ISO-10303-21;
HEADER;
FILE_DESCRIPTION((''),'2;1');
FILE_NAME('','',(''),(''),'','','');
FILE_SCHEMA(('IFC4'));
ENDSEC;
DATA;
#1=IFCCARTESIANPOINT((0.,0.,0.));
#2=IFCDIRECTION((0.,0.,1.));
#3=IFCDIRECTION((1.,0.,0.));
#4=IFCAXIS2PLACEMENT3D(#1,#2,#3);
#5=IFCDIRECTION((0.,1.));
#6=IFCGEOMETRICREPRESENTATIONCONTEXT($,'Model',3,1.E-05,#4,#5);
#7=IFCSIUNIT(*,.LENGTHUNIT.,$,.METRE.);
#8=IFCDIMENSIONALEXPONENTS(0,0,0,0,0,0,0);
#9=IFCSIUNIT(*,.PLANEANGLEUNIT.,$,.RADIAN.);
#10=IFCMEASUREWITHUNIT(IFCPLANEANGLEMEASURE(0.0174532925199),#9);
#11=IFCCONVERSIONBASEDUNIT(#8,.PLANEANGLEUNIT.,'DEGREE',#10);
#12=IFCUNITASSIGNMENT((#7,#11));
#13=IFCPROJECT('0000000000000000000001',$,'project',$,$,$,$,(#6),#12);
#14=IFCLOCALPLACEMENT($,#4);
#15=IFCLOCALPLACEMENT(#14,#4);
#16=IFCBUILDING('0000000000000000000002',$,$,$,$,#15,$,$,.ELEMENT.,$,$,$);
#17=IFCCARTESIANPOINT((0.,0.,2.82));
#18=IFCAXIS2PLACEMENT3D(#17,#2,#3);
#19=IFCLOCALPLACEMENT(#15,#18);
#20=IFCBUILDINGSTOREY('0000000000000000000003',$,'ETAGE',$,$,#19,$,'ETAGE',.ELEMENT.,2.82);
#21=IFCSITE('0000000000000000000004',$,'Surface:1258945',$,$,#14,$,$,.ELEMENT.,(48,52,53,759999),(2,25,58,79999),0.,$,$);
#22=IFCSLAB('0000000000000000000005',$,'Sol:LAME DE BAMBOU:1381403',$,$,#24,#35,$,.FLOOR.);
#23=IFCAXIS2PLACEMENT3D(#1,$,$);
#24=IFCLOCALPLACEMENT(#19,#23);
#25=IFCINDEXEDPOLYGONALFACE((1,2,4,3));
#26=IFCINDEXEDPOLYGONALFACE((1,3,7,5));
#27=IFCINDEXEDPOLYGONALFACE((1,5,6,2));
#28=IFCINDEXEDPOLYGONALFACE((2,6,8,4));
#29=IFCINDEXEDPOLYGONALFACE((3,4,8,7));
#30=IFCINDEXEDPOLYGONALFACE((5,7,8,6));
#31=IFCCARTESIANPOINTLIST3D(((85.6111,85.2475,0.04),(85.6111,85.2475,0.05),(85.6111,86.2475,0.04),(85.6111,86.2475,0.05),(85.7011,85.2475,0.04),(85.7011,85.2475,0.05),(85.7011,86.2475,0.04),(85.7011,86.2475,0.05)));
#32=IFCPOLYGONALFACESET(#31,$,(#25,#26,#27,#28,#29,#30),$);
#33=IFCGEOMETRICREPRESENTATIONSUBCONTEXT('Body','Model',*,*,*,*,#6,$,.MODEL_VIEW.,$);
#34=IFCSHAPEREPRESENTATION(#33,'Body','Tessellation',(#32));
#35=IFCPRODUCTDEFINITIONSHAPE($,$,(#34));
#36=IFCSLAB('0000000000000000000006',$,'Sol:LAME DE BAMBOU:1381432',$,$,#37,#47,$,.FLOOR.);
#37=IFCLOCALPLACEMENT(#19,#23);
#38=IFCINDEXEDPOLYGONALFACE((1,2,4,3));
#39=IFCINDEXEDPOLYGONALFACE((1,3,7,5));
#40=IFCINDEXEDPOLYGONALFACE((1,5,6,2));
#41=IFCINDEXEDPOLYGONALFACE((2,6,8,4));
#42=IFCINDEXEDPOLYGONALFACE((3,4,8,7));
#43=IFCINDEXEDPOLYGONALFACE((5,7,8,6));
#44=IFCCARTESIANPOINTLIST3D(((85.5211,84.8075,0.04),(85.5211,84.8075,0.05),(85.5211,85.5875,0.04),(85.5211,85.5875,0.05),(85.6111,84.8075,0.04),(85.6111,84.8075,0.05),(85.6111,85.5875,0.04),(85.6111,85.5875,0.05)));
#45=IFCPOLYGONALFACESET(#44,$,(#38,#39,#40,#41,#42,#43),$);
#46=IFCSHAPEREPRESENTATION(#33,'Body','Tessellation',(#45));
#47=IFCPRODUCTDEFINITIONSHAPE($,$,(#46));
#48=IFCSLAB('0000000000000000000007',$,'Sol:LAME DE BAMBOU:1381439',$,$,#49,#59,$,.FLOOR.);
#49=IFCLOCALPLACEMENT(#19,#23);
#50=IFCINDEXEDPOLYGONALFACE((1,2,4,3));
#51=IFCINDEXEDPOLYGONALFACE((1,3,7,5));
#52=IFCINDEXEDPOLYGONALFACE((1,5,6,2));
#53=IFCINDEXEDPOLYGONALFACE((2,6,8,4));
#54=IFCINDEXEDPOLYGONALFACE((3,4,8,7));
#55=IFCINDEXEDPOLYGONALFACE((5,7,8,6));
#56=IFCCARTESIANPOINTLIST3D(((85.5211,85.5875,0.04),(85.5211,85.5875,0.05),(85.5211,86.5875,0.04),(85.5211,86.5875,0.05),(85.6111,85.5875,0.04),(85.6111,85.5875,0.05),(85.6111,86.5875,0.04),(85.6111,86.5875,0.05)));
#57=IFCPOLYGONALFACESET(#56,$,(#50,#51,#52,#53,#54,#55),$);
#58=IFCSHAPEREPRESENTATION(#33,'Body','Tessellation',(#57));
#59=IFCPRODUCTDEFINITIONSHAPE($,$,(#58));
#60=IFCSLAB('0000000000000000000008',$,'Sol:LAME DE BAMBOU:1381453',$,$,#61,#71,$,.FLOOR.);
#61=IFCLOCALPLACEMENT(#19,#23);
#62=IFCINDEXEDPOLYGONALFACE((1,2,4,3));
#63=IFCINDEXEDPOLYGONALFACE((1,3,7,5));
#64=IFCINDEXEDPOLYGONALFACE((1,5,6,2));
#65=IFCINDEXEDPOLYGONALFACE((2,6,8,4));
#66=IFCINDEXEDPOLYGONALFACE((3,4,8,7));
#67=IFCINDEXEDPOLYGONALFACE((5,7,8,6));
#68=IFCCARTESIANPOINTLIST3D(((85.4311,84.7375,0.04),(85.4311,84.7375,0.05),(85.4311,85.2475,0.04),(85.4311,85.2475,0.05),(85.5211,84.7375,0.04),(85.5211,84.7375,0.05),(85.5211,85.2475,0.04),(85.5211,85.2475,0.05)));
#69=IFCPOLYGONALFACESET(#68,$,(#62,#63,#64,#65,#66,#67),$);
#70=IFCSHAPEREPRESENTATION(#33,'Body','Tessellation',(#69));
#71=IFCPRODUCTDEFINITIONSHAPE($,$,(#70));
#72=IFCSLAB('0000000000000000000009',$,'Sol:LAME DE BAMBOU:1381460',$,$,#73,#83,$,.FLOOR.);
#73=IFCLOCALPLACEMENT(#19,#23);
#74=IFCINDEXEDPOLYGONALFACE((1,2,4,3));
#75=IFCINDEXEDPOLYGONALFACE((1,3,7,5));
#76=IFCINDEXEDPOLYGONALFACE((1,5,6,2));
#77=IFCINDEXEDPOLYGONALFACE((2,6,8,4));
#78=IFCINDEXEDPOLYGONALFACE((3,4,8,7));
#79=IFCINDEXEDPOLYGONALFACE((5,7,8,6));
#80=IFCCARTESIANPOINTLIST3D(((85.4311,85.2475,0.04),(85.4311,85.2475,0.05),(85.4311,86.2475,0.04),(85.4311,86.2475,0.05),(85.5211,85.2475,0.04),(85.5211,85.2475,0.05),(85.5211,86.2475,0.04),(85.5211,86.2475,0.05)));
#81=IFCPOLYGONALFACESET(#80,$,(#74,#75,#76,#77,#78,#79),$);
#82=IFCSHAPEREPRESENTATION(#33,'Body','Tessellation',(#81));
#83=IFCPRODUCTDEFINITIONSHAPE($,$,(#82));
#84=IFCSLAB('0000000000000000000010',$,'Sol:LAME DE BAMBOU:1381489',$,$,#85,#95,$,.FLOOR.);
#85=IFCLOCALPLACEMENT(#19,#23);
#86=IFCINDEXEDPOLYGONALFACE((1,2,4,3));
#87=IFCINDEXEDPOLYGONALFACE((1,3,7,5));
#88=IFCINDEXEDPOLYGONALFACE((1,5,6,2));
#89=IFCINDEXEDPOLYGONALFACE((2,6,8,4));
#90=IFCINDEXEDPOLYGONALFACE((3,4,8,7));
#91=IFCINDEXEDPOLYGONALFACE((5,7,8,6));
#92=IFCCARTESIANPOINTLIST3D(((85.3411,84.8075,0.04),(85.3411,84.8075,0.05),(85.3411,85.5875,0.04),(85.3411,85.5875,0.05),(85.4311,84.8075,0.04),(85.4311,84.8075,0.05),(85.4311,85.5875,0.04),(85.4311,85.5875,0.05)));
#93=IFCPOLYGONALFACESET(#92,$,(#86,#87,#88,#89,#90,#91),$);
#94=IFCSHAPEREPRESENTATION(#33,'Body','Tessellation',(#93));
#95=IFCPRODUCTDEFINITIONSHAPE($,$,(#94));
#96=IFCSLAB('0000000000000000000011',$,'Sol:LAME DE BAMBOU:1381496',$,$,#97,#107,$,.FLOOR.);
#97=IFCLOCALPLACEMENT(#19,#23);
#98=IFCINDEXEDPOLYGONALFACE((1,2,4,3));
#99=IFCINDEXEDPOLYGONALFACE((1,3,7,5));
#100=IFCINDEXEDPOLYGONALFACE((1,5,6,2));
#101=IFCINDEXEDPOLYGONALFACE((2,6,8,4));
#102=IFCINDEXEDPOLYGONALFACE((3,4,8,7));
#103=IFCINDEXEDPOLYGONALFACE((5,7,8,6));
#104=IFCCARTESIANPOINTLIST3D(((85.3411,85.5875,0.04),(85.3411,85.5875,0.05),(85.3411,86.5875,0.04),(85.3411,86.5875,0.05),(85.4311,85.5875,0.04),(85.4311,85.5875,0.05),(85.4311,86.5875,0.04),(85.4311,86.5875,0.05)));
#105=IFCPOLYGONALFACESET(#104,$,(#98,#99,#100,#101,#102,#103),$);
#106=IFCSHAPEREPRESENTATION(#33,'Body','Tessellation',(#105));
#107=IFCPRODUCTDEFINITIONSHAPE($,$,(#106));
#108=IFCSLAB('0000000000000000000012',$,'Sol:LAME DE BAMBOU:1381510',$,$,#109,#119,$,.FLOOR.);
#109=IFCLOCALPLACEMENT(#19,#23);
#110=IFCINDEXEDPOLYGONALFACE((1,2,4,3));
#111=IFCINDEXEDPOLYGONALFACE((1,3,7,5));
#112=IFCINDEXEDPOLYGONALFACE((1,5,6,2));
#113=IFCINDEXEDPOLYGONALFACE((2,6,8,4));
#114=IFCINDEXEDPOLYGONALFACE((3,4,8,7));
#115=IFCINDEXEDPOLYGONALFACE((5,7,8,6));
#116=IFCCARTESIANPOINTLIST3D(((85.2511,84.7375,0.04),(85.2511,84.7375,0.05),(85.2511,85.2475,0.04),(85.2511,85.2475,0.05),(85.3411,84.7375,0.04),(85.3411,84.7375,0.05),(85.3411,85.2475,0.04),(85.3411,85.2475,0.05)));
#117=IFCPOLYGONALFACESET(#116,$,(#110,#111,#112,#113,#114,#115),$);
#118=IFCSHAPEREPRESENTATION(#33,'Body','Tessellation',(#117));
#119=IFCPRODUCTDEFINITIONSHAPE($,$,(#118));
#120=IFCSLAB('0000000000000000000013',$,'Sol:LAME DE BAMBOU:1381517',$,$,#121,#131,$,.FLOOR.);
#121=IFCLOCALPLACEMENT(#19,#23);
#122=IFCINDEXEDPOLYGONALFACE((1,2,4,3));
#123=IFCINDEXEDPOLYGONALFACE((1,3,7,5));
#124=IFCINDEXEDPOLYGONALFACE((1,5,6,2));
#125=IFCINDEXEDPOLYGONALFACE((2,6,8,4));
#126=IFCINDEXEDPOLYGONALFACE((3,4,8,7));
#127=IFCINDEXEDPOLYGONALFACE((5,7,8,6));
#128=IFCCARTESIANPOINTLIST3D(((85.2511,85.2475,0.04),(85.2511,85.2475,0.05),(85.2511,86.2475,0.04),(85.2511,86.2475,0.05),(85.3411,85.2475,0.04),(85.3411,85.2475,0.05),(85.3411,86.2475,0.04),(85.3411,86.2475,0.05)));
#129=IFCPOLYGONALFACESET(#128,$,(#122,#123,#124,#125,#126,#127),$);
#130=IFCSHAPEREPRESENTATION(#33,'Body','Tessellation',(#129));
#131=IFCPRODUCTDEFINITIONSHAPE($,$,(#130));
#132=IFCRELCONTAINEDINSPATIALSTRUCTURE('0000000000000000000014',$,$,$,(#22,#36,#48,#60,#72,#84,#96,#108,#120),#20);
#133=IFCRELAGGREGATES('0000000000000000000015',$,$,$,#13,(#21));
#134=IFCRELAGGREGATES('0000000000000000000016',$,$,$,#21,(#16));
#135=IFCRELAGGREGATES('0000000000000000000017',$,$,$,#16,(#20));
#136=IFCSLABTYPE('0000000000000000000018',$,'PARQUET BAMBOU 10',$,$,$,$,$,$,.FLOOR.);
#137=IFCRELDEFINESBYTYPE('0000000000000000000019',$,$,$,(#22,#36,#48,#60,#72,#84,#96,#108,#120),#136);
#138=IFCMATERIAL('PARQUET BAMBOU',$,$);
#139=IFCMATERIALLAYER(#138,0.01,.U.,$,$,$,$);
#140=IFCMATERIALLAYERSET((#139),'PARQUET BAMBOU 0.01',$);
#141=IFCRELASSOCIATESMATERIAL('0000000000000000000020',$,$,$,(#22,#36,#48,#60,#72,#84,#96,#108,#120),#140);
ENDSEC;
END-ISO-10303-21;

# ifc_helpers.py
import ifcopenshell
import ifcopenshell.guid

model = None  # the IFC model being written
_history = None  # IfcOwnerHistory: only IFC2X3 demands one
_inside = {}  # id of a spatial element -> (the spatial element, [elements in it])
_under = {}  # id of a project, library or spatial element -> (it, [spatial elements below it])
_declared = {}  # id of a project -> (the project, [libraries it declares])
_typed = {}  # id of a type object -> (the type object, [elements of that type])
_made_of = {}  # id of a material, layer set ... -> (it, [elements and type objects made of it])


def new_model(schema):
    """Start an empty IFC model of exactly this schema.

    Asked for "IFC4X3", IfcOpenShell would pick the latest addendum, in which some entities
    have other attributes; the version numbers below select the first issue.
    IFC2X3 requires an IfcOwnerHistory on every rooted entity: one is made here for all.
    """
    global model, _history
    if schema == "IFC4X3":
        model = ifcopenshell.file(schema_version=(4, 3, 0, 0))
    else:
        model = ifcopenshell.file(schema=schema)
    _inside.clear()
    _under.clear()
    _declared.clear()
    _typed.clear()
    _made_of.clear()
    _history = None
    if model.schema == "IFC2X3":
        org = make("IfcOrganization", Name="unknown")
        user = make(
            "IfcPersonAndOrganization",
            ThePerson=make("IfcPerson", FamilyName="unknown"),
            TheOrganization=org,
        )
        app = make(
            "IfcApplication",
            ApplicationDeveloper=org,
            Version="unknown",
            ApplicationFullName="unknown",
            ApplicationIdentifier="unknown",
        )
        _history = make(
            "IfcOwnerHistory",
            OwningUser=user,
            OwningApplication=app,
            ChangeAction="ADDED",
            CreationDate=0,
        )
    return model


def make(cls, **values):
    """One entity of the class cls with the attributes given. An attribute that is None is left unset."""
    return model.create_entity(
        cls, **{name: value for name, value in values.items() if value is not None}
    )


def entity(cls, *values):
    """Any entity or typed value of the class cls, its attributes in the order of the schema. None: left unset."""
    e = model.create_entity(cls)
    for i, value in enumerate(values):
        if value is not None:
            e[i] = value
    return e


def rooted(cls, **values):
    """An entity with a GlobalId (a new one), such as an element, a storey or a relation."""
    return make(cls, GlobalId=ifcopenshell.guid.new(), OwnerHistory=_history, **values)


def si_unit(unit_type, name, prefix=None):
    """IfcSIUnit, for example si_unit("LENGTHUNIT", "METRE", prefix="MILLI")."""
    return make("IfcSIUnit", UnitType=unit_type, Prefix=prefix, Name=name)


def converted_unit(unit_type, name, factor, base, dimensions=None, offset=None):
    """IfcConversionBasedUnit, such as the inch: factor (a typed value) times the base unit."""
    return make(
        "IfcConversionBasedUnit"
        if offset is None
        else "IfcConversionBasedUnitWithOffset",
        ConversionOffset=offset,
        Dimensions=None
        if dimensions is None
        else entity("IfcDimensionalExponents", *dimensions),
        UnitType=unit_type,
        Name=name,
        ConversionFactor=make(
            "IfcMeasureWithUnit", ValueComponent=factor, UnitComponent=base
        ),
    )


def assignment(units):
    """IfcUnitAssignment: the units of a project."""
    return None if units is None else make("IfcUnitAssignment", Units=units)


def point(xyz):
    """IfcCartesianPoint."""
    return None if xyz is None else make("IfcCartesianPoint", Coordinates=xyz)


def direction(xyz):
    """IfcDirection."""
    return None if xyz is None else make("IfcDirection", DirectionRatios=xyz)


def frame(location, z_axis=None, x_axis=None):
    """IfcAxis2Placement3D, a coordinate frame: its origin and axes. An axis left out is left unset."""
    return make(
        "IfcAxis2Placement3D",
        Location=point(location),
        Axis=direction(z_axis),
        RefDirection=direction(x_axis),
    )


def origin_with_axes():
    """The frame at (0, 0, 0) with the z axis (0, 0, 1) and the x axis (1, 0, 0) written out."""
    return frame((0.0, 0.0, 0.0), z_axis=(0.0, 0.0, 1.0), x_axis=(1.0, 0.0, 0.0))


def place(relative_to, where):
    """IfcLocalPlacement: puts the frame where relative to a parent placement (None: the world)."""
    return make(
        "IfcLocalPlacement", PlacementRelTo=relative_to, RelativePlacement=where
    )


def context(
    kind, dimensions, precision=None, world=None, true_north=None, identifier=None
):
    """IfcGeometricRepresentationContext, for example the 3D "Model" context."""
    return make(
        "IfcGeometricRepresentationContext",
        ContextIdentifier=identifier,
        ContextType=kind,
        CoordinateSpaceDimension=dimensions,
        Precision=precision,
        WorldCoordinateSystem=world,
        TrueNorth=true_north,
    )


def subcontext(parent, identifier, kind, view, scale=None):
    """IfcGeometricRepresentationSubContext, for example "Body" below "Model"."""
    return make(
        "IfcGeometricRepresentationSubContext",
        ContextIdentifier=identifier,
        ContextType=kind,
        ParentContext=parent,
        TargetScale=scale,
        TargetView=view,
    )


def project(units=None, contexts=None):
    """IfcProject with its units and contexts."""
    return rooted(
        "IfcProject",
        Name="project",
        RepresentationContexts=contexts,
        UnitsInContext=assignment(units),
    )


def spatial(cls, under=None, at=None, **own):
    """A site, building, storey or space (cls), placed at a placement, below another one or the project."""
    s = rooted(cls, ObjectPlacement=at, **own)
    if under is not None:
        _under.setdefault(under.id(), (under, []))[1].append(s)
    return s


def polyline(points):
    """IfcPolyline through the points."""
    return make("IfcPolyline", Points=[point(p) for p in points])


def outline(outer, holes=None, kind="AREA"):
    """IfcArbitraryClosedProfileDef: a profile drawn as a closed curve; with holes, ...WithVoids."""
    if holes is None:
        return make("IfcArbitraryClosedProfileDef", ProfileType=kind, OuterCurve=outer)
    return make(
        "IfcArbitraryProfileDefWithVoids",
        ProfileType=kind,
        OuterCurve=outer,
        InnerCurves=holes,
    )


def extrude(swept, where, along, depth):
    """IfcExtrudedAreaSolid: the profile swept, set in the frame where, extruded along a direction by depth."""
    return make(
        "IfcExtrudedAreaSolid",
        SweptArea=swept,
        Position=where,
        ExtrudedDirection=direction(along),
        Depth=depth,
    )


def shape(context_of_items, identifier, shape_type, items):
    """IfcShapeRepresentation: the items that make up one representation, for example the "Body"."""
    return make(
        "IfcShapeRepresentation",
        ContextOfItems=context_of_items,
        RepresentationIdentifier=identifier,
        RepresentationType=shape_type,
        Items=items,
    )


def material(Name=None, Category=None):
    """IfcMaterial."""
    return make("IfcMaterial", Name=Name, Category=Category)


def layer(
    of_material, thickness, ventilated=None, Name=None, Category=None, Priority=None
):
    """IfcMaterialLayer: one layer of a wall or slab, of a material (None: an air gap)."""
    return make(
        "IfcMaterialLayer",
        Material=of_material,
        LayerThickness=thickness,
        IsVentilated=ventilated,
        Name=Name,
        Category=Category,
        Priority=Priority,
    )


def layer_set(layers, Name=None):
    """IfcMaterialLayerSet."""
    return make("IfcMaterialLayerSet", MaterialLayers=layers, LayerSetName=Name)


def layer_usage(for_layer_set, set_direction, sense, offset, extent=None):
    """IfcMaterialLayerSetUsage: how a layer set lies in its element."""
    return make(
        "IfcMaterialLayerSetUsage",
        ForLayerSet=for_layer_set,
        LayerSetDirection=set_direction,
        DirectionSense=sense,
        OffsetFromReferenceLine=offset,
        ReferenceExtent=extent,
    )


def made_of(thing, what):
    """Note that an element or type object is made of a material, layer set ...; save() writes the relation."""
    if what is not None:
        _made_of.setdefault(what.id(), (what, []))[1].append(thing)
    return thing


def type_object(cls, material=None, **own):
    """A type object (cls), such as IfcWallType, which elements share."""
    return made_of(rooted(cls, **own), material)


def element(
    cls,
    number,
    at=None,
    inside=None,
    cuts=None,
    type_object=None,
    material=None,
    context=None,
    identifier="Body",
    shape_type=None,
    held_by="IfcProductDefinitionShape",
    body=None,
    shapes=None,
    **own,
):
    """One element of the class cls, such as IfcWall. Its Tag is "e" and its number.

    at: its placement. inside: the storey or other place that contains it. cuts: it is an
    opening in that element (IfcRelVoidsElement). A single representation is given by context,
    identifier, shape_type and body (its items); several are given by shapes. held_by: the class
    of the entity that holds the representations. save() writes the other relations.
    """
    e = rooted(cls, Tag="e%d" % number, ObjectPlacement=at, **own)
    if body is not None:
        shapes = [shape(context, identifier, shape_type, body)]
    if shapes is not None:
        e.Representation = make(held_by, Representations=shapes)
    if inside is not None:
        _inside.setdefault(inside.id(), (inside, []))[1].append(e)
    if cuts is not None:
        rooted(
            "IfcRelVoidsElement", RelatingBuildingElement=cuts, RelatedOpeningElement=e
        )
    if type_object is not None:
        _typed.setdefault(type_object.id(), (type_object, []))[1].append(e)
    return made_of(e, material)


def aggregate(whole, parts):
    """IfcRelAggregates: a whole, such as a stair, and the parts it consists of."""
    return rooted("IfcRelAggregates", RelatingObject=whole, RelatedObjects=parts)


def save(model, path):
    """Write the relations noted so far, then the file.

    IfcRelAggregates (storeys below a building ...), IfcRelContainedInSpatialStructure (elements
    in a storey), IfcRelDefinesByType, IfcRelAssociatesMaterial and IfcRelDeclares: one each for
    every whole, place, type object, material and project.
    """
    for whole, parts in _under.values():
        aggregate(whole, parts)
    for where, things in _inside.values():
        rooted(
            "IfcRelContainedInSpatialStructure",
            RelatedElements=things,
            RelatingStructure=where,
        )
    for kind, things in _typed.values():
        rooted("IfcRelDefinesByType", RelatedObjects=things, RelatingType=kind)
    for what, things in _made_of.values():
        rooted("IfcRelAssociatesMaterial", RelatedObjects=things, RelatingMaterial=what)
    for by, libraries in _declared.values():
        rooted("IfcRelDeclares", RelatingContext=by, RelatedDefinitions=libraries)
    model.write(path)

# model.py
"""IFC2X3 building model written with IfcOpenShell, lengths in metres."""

from ifc_helpers import new_model, entity, si_unit, converted_unit, direction, frame, origin_with_axes, place, context, subcontext, project, spatial, polyline, outline, extrude, material, layer, layer_set, layer_usage, type_object, element, save


model = new_model("IFC2X3")

# Units and contexts
model_context = context("Model", 3, precision=1e-05, world=origin_with_axes(), true_north=direction((0.0, 1.0)))
body_context = subcontext(model_context, "Body", "Model", "MODEL_VIEW")
ifc_project = project(units=[si_unit("LENGTHUNIT", "METRE"), converted_unit("PLANEANGLEUNIT", "DEGREE", entity("IfcPlaneAngleMeasure", 0.0174532925199), si_unit("PLANEANGLEUNIT", "RADIAN"), dimensions=[0, 0, 0, 0, 0, 0, 0])], contexts=[model_context])

# Site, building, storey
site_placement = place(None, origin_with_axes())
site = spatial("IfcSite", under=ifc_project, at=site_placement, Name="Surface:1258945", CompositionType="ELEMENT", RefLatitude=(48, 52, 53, 759999), RefLongitude=(2, 25, 58, 79999), RefElevation=0.0)
building_placement = place(site_placement, origin_with_axes())
building = spatial("IfcBuilding", under=site, at=building_placement, CompositionType="ELEMENT")
storey_placement = place(building_placement, frame((0.0, 0.0, 2.82), z_axis=(0.0, 0.0, 1.0), x_axis=(1.0, 0.0, 0.0)))
storey = spatial("IfcBuildingStorey", under=building, at=storey_placement, Name="ETAGE", LongName="ETAGE", CompositionType="ELEMENT", Elevation=2.82)

# Slabs
ifc_material = material(Name="PARQUET BAMBOU")
ifc_layer = layer(ifc_material, 0.01, ventilated="UNKNOWN")
ifc_layer_set = layer_set([ifc_layer], Name="PARQUET BAMBOU 0.01")
slab_type = type_object("IfcSlabType", Name="PARQUET BAMBOU 10", PredefinedType="FLOOR")
ifc_layer_usage_1 = layer_usage(ifc_layer_set, "AXIS3", "NEGATIVE", 0.01)
slab_1_placement = place(storey_placement, frame((85.6111, 86.2475, 0.05), z_axis=(0.0, 0.0, 1.0), x_axis=(1.0, 0.0, 0.0)))
element("IfcSlab", 1, at=slab_1_placement, inside=storey, type_object=slab_type, material=ifc_layer_usage_1, Name="Sol:LAME DE BAMBOU:1381403", PredefinedType="FLOOR", context=body_context, shape_type="SweptSolid", body=[
    extrude(outline(polyline([(0.0, 0.0), (0.0, -1.0), (0.09, -1.0), (0.09, 0.0), (0.0, 0.0)])), frame((0.0, 0.0, -0.01), z_axis=(0.0, 0.0, 1.0), x_axis=(1.0, 0.0, 0.0)), (0.0, 0.0, 1.0), 0.01),
])
ifc_layer_usage_2 = layer_usage(ifc_layer_set, "AXIS3", "NEGATIVE", 0.01)
slab_2_placement = place(storey_placement, frame((85.5211, 85.5875, 0.05), z_axis=(0.0, 0.0, 1.0), x_axis=(1.0, 0.0, 0.0)))
element("IfcSlab", 2, at=slab_2_placement, inside=storey, type_object=slab_type, material=ifc_layer_usage_2, Name="Sol:LAME DE BAMBOU:1381432", PredefinedType="FLOOR", context=body_context, shape_type="SweptSolid", body=[
    extrude(outline(polyline([(0.0, 0.0), (0.0, -0.78), (0.09, -0.78), (0.09, 0.0), (0.0, 0.0)])), frame((0.0, 0.0, -0.01), z_axis=(0.0, 0.0, 1.0), x_axis=(1.0, 0.0, 0.0)), (0.0, 0.0, 1.0), 0.01),
])
ifc_layer_usage_3 = layer_usage(ifc_layer_set, "AXIS3", "NEGATIVE", 0.01)
slab_3_placement = place(storey_placement, frame((85.5211, 86.5875, 0.05), z_axis=(0.0, 0.0, 1.0), x_axis=(1.0, 0.0, 0.0)))
element("IfcSlab", 3, at=slab_3_placement, inside=storey, type_object=slab_type, material=ifc_layer_usage_3, Name="Sol:LAME DE BAMBOU:1381439", PredefinedType="FLOOR", context=body_context, shape_type="SweptSolid", body=[
    extrude(outline(polyline([(0.0, 0.0), (0.0, -1.0), (0.09, -1.0), (0.09, 0.0), (0.0, 0.0)])), frame((0.0, 0.0, -0.01), z_axis=(0.0, 0.0, 1.0), x_axis=(1.0, 0.0, 0.0)), (0.0, 0.0, 1.0), 0.01),
])
ifc_layer_usage_4 = layer_usage(ifc_layer_set, "AXIS3", "NEGATIVE", 0.01)
slab_4_placement = place(storey_placement, frame((85.4311, 85.2475, 0.05), z_axis=(0.0, 0.0, 1.0), x_axis=(1.0, 0.0, 0.0)))
element("IfcSlab", 4, at=slab_4_placement, inside=storey, type_object=slab_type, material=ifc_layer_usage_4, Name="Sol:LAME DE BAMBOU:1381453", PredefinedType="FLOOR", context=body_context, shape_type="SweptSolid", body=[
    extrude(outline(polyline([(0.0, 0.0), (0.0, -0.51), (0.09, -0.51), (0.09, 0.0), (0.0, 0.0)])), frame((0.0, 0.0, -0.01), z_axis=(0.0, 0.0, 1.0), x_axis=(1.0, 0.0, 0.0)), (0.0, 0.0, 1.0), 0.01),
])
ifc_layer_usage_5 = layer_usage(ifc_layer_set, "AXIS3", "NEGATIVE", 0.01)
slab_5_placement = place(storey_placement, frame((85.4311, 86.2475, 0.05), z_axis=(0.0, 0.0, 1.0), x_axis=(1.0, 0.0, 0.0)))
element("IfcSlab", 5, at=slab_5_placement, inside=storey, type_object=slab_type, material=ifc_layer_usage_5, Name="Sol:LAME DE BAMBOU:1381460", PredefinedType="FLOOR", context=body_context, shape_type="SweptSolid", body=[
    extrude(outline(polyline([(0.0, 0.0), (0.0, -1.0), (0.09, -1.0), (0.09, 0.0), (0.0, 0.0)])), frame((0.0, 0.0, -0.01), z_axis=(0.0, 0.0, 1.0), x_axis=(1.0, 0.0, 0.0)), (0.0, 0.0, 1.0), 0.01),
])
ifc_layer_usage_6 = layer_usage(ifc_layer_set, "AXIS3", "NEGATIVE", 0.01)
slab_6_placement = place(storey_placement, frame((85.3411, 85.5875, 0.05), z_axis=(0.0, 0.0, 1.0), x_axis=(1.0, 0.0, 0.0)))
element("IfcSlab", 6, at=slab_6_placement, inside=storey, type_object=slab_type, material=ifc_layer_usage_6, Name="Sol:LAME DE BAMBOU:1381489", PredefinedType="FLOOR", context=body_context, shape_type="SweptSolid", body=[
    extrude(outline(polyline([(0.0, 0.0), (0.0, -0.78), (0.09, -0.78), (0.09, 0.0), (0.0, 0.0)])), frame((0.0, 0.0, -0.01), z_axis=(0.0, 0.0, 1.0), x_axis=(1.0, 0.0, 0.0)), (0.0, 0.0, 1.0), 0.01),
])
ifc_layer_usage_7 = layer_usage(ifc_layer_set, "AXIS3", "NEGATIVE", 0.01)
slab_7_placement = place(storey_placement, frame((85.3411, 86.5875, 0.05), z_axis=(0.0, 0.0, 1.0), x_axis=(1.0, 0.0, 0.0)))
element("IfcSlab", 7, at=slab_7_placement, inside=storey, type_object=slab_type, material=ifc_layer_usage_7, Name="Sol:LAME DE BAMBOU:1381496", PredefinedType="FLOOR", context=body_context, shape_type="SweptSolid", body=[
    extrude(outline(polyline([(0.0, 0.0), (0.0, -1.0), (0.09, -1.0), (0.09, 0.0), (0.0, 0.0)])), frame((0.0, 0.0, -0.01), z_axis=(0.0, 0.0, 1.0), x_axis=(1.0, 0.0, 0.0)), (0.0, 0.0, 1.0), 0.01),
])
ifc_layer_usage_8 = layer_usage(ifc_layer_set, "AXIS3", "NEGATIVE", 0.01)
slab_8_placement = place(storey_placement, frame((85.2511, 85.2475, 0.05), z_axis=(0.0, 0.0, 1.0), x_axis=(1.0, 0.0, 0.0)))
element("IfcSlab", 8, at=slab_8_placement, inside=storey, type_object=slab_type, material=ifc_layer_usage_8, Name="Sol:LAME DE BAMBOU:1381510", PredefinedType="FLOOR", context=body_context, shape_type="SweptSolid", body=[
    extrude(outline(polyline([(0.0, 0.0), (0.0, -0.51), (0.09, -0.51), (0.09, 0.0), (0.0, 0.0)])), frame((0.0, 0.0, -0.01), z_axis=(0.0, 0.0, 1.0), x_axis=(1.0, 0.0, 0.0)), (0.0, 0.0, 1.0), 0.01),
])
ifc_layer_usage_9 = layer_usage(ifc_layer_set, "AXIS3", "NEGATIVE", 0.01)
slab_9_placement = place(storey_placement, frame((85.2511, 86.2475, 0.05), z_axis=(0.0, 0.0, 1.0), x_axis=(1.0, 0.0, 0.0)))
element("IfcSlab", 9, at=slab_9_placement, inside=storey, type_object=slab_type, material=ifc_layer_usage_9, Name="Sol:LAME DE BAMBOU:1381517", PredefinedType="FLOOR", context=body_context, shape_type="SweptSolid", body=[
    extrude(outline(polyline([(0.0, 0.0), (0.0, -1.0), (0.09, -1.0), (0.09, 0.0), (0.0, 0.0)])), frame((0.0, 0.0, -0.01), z_axis=(0.0, 0.0, 1.0), x_axis=(1.0, 0.0, 0.0)), (0.0, 0.0, 1.0), 0.01),
])

save(model, "model.ifc")
